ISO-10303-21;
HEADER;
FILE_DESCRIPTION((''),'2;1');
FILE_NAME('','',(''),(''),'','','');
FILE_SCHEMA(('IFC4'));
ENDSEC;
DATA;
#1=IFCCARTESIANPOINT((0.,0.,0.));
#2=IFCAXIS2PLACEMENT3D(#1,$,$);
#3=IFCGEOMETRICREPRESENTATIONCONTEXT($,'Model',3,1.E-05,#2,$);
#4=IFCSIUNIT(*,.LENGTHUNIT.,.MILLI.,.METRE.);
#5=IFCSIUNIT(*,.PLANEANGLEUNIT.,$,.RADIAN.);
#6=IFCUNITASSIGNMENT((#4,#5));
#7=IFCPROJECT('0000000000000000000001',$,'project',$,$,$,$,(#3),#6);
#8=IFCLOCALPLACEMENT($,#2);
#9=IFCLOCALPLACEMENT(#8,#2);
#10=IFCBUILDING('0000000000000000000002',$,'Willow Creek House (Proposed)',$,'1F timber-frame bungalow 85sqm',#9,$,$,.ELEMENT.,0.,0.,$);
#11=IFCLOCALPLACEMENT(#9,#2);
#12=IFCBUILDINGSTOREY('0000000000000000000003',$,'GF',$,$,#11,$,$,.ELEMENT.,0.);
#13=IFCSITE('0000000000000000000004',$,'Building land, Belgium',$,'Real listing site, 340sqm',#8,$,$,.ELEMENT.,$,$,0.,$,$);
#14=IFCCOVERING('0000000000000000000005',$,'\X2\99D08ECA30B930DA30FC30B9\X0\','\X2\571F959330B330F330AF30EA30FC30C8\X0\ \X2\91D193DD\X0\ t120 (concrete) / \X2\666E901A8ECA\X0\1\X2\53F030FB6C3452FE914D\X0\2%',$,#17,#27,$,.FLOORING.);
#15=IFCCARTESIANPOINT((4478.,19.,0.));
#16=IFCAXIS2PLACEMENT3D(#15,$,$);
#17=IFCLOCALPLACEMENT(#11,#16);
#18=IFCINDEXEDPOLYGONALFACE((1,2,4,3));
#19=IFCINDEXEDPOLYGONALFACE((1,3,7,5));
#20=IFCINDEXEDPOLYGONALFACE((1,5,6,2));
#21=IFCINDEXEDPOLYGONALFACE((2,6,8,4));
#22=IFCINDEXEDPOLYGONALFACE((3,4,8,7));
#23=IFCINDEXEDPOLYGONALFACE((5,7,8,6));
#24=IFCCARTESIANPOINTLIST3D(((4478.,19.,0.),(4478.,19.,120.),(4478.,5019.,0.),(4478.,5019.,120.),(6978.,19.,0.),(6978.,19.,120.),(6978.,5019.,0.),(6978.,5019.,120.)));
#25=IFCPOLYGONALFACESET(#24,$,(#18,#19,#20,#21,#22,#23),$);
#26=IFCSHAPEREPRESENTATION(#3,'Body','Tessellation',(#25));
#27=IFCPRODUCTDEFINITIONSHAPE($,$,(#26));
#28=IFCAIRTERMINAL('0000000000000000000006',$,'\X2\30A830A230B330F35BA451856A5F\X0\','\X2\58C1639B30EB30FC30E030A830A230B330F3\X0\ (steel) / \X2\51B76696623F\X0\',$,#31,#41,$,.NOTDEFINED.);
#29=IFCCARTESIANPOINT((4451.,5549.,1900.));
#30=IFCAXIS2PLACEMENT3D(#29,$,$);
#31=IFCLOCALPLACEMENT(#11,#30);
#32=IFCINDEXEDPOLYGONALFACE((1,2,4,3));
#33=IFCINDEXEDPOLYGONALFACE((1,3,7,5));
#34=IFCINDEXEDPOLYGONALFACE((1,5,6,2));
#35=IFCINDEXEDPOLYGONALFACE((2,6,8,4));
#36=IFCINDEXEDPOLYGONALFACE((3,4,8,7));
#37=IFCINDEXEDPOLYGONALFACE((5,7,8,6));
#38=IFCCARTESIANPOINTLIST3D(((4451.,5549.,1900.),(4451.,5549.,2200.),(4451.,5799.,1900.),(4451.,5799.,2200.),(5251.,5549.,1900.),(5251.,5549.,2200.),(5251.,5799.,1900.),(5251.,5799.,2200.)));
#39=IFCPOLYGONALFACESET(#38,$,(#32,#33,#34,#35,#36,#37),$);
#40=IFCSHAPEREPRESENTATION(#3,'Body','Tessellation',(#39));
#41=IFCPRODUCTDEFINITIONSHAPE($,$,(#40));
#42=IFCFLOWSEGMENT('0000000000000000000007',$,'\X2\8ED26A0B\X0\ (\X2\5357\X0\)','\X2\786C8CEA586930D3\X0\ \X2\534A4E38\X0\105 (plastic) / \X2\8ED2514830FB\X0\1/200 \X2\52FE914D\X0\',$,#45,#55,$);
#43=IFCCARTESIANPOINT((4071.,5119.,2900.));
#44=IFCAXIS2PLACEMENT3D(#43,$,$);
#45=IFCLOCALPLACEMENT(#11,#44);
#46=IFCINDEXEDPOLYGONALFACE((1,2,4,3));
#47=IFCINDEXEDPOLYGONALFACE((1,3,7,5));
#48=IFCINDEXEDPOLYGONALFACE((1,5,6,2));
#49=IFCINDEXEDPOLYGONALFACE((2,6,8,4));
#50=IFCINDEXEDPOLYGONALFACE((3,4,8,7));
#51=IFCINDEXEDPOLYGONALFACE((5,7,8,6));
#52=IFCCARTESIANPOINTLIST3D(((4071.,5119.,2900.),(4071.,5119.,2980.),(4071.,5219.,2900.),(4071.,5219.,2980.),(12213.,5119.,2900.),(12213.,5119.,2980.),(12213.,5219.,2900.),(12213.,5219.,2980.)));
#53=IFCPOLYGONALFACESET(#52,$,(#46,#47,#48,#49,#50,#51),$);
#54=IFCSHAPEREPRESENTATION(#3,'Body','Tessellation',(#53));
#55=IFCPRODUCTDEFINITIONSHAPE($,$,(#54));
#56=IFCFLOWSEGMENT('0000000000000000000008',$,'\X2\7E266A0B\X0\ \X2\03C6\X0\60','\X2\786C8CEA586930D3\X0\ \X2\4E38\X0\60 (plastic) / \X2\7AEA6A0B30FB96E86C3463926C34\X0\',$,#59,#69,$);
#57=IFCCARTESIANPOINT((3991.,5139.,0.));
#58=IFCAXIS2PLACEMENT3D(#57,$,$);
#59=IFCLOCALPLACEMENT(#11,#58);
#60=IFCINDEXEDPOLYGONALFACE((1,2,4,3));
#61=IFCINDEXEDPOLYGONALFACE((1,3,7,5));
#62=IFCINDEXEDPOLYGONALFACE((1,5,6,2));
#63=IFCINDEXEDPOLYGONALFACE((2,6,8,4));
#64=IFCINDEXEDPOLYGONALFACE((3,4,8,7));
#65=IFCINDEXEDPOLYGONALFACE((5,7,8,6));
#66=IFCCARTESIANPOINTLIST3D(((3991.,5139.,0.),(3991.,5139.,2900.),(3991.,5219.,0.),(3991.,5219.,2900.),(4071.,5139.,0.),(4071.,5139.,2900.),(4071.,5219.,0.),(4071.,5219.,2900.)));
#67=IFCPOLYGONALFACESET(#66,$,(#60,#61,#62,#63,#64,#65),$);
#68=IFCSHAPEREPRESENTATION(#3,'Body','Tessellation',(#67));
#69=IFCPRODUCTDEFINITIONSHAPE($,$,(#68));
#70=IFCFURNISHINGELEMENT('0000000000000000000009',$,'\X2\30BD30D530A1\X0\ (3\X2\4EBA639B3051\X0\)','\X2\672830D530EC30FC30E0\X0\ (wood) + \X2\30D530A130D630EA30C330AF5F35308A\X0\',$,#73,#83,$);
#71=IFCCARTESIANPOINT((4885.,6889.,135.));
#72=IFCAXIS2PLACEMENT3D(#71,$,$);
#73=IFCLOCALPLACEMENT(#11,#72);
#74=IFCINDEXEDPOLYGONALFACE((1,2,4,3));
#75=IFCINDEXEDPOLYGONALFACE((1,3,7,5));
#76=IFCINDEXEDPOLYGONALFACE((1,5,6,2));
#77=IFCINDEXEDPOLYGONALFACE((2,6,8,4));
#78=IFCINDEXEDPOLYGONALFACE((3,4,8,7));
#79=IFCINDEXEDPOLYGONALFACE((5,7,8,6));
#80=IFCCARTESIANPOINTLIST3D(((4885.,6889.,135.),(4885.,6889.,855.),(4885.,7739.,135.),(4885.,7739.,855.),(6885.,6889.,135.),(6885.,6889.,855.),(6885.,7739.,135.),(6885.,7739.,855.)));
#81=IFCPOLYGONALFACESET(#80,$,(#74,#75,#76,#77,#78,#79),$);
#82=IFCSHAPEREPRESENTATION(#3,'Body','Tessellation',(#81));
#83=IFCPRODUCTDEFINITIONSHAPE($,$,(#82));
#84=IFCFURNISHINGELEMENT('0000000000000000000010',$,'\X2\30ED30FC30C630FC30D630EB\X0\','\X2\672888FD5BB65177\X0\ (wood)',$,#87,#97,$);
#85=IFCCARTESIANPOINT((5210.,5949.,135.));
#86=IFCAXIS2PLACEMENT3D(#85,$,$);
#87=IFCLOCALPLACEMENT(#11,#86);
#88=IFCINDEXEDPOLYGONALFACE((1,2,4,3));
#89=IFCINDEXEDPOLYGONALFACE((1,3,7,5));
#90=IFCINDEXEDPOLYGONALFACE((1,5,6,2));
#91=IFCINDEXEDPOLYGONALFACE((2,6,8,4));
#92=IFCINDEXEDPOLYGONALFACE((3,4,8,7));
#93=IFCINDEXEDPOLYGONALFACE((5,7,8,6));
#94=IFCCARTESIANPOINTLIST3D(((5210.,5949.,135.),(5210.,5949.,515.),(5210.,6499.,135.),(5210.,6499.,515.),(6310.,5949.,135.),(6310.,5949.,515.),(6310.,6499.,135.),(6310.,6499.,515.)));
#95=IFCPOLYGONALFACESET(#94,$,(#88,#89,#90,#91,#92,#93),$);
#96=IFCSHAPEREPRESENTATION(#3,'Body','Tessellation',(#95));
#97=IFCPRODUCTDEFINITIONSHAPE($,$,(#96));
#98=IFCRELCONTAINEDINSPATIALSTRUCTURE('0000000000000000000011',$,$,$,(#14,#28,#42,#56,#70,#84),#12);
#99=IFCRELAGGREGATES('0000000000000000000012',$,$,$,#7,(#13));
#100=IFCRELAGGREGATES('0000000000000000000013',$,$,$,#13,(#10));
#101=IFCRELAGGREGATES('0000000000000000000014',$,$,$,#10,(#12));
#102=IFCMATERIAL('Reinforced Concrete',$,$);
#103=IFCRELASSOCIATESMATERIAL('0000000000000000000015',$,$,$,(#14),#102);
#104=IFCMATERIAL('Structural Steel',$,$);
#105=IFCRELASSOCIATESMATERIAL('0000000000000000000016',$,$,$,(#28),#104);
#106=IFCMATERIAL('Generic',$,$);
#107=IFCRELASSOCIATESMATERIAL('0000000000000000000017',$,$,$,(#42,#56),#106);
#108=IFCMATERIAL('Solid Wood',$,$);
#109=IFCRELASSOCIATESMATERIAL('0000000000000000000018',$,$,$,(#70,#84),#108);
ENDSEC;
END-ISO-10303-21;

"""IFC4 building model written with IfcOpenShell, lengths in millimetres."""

from ifc_helpers import new_model, si_unit, frame, frame_2d, origin, place, context, project, spatial, rectangle, extrude, material, element, save


model = new_model("IFC4")

# Units and contexts
model_context = context("Model", 3, precision=1e-05, world=origin())
ifc_project = project(units=[si_unit("LENGTHUNIT", "METRE", prefix="MILLI"), si_unit("PLANEANGLEUNIT", "RADIAN")], contexts=[model_context])

# Site, building, storey
site_placement = place(None, origin())
site = spatial("IfcSite", under=ifc_project, at=site_placement, Name="Building land, Belgium", ObjectType="Real listing site, 340sqm", CompositionType="ELEMENT", RefElevation=0.0)
building_placement = place(site_placement, origin())
building = spatial("IfcBuilding", under=site, at=building_placement, Name="Willow Creek House (Proposed)", ObjectType="1F timber-frame bungalow 85sqm", CompositionType="ELEMENT", ElevationOfRefHeight=0.0, ElevationOfTerrain=0.0)
storey_placement = place(building_placement, origin())
storey = spatial("IfcBuildingStorey", under=building, at=storey_placement, Name="GF", CompositionType="ELEMENT", Elevation=0.0)

# Shared definitions
ifc_material_1 = material(Name="Solid Wood")

# Shared definitions
ifc_material_2 = material(Name="Reinforced Concrete")

# Shared definitions
ifc_material_3 = material(Name="Structural Steel")

# Covering
ifc_material_4 = material(Name="Generic")
covering_1_placement = place(storey_placement, frame((4478.0, 19.0, 0.0)))
element("IfcCovering", 1, at=covering_1_placement, inside=storey, material=ifc_material_2, Name="駐車スペース", Description="土間コンクリート 金鏝 t120 (concrete) / 普通車1台・水勾配2%", PredefinedType="FLOORING", context=model_context, shape_type="SweptSolid", body=[
    extrude(rectangle(XDim=2500.0, YDim=5000.0, at=frame_2d((1250.0, 2500.0))), frame((4478.0, 19.0, 0.0)), (0.0, 0.0, 1.0), 120.0),
])

# Air terminal
air_terminal_placement = place(storey_placement, frame((4451.0, 5549.0, 1900.0)))
element("IfcAirTerminal", 2, at=air_terminal_placement, inside=storey, material=ifc_material_3, Name="エアコン室内機", Description="壁掛ルームエアコン (steel) / 冷暖房", PredefinedType="NOTDEFINED", context=model_context, shape_type="SweptSolid", body=[
    extrude(rectangle(XDim=800.0, YDim=250.0, at=frame_2d((400.0, 125.0))), frame((4451.0, 5549.0, 1900.0)), (0.0, 0.0, 1.0), 300.0),
])

# Flow segments
flow_segment_1_placement = place(storey_placement, frame((4071.0, 5119.0, 2900.0)))
element("IfcFlowSegment", 3, at=flow_segment_1_placement, inside=storey, material=ifc_material_4, Name="軒樋 (南)", Description="硬質塩ビ 半丸105 (plastic) / 軒先・1/200 勾配", context=model_context, shape_type="SweptSolid", body=[
    extrude(rectangle(XDim=8142.0, YDim=100.0, at=frame_2d((4071.0, 50.0))), frame((4071.0, 5119.0, 2900.0)), (0.0, 0.0, 1.0), 80.0),
])
flow_segment_2_placement = place(storey_placement, frame((3991.0, 5139.0, 0.0)))
element("IfcFlowSegment", 4, at=flow_segment_2_placement, inside=storey, material=ifc_material_4, Name="縦樋 φ60", Description="硬質塩ビ 丸60 (plastic) / 竪樋・雨水排水", context=model_context, shape_type="SweptSolid", body=[
    extrude(rectangle(XDim=80.0, YDim=80.0, at=frame_2d((40.0, 40.0))), frame((3991.0, 5139.0, 0.0)), (0.0, 0.0, 1.0), 2900.0),
])

# Furnishing elements
furnishing_1_placement = place(storey_placement, frame((4885.0, 6889.0, 135.0)))
element("IfcFurnishingElement", 5, at=furnishing_1_placement, inside=storey, material=ifc_material_1, Name="ソファ (3人掛け)", Description="木フレーム (wood) + ファブリック張り", context=model_context, shape_type="SweptSolid", body=[
    extrude(rectangle(XDim=2000.0, YDim=850.0, at=frame_2d((1000.0, 425.0))), frame((4885.0, 6889.0, 135.0)), (0.0, 0.0, 1.0), 720.0),
])
furnishing_2_placement = place(storey_placement, frame((5210.0, 5949.0, 135.0)))
element("IfcFurnishingElement", 6, at=furnishing_2_placement, inside=storey, material=ifc_material_1, Name="ローテーブル", Description="木製家具 (wood)", context=model_context, shape_type="SweptSolid", body=[
    extrude(rectangle(XDim=1100.0, YDim=550.0, at=frame_2d((550.0, 275.0))), frame((5210.0, 5949.0, 135.0)), (0.0, 0.0, 1.0), 380.0),
])

save(model, "model.ifc")
